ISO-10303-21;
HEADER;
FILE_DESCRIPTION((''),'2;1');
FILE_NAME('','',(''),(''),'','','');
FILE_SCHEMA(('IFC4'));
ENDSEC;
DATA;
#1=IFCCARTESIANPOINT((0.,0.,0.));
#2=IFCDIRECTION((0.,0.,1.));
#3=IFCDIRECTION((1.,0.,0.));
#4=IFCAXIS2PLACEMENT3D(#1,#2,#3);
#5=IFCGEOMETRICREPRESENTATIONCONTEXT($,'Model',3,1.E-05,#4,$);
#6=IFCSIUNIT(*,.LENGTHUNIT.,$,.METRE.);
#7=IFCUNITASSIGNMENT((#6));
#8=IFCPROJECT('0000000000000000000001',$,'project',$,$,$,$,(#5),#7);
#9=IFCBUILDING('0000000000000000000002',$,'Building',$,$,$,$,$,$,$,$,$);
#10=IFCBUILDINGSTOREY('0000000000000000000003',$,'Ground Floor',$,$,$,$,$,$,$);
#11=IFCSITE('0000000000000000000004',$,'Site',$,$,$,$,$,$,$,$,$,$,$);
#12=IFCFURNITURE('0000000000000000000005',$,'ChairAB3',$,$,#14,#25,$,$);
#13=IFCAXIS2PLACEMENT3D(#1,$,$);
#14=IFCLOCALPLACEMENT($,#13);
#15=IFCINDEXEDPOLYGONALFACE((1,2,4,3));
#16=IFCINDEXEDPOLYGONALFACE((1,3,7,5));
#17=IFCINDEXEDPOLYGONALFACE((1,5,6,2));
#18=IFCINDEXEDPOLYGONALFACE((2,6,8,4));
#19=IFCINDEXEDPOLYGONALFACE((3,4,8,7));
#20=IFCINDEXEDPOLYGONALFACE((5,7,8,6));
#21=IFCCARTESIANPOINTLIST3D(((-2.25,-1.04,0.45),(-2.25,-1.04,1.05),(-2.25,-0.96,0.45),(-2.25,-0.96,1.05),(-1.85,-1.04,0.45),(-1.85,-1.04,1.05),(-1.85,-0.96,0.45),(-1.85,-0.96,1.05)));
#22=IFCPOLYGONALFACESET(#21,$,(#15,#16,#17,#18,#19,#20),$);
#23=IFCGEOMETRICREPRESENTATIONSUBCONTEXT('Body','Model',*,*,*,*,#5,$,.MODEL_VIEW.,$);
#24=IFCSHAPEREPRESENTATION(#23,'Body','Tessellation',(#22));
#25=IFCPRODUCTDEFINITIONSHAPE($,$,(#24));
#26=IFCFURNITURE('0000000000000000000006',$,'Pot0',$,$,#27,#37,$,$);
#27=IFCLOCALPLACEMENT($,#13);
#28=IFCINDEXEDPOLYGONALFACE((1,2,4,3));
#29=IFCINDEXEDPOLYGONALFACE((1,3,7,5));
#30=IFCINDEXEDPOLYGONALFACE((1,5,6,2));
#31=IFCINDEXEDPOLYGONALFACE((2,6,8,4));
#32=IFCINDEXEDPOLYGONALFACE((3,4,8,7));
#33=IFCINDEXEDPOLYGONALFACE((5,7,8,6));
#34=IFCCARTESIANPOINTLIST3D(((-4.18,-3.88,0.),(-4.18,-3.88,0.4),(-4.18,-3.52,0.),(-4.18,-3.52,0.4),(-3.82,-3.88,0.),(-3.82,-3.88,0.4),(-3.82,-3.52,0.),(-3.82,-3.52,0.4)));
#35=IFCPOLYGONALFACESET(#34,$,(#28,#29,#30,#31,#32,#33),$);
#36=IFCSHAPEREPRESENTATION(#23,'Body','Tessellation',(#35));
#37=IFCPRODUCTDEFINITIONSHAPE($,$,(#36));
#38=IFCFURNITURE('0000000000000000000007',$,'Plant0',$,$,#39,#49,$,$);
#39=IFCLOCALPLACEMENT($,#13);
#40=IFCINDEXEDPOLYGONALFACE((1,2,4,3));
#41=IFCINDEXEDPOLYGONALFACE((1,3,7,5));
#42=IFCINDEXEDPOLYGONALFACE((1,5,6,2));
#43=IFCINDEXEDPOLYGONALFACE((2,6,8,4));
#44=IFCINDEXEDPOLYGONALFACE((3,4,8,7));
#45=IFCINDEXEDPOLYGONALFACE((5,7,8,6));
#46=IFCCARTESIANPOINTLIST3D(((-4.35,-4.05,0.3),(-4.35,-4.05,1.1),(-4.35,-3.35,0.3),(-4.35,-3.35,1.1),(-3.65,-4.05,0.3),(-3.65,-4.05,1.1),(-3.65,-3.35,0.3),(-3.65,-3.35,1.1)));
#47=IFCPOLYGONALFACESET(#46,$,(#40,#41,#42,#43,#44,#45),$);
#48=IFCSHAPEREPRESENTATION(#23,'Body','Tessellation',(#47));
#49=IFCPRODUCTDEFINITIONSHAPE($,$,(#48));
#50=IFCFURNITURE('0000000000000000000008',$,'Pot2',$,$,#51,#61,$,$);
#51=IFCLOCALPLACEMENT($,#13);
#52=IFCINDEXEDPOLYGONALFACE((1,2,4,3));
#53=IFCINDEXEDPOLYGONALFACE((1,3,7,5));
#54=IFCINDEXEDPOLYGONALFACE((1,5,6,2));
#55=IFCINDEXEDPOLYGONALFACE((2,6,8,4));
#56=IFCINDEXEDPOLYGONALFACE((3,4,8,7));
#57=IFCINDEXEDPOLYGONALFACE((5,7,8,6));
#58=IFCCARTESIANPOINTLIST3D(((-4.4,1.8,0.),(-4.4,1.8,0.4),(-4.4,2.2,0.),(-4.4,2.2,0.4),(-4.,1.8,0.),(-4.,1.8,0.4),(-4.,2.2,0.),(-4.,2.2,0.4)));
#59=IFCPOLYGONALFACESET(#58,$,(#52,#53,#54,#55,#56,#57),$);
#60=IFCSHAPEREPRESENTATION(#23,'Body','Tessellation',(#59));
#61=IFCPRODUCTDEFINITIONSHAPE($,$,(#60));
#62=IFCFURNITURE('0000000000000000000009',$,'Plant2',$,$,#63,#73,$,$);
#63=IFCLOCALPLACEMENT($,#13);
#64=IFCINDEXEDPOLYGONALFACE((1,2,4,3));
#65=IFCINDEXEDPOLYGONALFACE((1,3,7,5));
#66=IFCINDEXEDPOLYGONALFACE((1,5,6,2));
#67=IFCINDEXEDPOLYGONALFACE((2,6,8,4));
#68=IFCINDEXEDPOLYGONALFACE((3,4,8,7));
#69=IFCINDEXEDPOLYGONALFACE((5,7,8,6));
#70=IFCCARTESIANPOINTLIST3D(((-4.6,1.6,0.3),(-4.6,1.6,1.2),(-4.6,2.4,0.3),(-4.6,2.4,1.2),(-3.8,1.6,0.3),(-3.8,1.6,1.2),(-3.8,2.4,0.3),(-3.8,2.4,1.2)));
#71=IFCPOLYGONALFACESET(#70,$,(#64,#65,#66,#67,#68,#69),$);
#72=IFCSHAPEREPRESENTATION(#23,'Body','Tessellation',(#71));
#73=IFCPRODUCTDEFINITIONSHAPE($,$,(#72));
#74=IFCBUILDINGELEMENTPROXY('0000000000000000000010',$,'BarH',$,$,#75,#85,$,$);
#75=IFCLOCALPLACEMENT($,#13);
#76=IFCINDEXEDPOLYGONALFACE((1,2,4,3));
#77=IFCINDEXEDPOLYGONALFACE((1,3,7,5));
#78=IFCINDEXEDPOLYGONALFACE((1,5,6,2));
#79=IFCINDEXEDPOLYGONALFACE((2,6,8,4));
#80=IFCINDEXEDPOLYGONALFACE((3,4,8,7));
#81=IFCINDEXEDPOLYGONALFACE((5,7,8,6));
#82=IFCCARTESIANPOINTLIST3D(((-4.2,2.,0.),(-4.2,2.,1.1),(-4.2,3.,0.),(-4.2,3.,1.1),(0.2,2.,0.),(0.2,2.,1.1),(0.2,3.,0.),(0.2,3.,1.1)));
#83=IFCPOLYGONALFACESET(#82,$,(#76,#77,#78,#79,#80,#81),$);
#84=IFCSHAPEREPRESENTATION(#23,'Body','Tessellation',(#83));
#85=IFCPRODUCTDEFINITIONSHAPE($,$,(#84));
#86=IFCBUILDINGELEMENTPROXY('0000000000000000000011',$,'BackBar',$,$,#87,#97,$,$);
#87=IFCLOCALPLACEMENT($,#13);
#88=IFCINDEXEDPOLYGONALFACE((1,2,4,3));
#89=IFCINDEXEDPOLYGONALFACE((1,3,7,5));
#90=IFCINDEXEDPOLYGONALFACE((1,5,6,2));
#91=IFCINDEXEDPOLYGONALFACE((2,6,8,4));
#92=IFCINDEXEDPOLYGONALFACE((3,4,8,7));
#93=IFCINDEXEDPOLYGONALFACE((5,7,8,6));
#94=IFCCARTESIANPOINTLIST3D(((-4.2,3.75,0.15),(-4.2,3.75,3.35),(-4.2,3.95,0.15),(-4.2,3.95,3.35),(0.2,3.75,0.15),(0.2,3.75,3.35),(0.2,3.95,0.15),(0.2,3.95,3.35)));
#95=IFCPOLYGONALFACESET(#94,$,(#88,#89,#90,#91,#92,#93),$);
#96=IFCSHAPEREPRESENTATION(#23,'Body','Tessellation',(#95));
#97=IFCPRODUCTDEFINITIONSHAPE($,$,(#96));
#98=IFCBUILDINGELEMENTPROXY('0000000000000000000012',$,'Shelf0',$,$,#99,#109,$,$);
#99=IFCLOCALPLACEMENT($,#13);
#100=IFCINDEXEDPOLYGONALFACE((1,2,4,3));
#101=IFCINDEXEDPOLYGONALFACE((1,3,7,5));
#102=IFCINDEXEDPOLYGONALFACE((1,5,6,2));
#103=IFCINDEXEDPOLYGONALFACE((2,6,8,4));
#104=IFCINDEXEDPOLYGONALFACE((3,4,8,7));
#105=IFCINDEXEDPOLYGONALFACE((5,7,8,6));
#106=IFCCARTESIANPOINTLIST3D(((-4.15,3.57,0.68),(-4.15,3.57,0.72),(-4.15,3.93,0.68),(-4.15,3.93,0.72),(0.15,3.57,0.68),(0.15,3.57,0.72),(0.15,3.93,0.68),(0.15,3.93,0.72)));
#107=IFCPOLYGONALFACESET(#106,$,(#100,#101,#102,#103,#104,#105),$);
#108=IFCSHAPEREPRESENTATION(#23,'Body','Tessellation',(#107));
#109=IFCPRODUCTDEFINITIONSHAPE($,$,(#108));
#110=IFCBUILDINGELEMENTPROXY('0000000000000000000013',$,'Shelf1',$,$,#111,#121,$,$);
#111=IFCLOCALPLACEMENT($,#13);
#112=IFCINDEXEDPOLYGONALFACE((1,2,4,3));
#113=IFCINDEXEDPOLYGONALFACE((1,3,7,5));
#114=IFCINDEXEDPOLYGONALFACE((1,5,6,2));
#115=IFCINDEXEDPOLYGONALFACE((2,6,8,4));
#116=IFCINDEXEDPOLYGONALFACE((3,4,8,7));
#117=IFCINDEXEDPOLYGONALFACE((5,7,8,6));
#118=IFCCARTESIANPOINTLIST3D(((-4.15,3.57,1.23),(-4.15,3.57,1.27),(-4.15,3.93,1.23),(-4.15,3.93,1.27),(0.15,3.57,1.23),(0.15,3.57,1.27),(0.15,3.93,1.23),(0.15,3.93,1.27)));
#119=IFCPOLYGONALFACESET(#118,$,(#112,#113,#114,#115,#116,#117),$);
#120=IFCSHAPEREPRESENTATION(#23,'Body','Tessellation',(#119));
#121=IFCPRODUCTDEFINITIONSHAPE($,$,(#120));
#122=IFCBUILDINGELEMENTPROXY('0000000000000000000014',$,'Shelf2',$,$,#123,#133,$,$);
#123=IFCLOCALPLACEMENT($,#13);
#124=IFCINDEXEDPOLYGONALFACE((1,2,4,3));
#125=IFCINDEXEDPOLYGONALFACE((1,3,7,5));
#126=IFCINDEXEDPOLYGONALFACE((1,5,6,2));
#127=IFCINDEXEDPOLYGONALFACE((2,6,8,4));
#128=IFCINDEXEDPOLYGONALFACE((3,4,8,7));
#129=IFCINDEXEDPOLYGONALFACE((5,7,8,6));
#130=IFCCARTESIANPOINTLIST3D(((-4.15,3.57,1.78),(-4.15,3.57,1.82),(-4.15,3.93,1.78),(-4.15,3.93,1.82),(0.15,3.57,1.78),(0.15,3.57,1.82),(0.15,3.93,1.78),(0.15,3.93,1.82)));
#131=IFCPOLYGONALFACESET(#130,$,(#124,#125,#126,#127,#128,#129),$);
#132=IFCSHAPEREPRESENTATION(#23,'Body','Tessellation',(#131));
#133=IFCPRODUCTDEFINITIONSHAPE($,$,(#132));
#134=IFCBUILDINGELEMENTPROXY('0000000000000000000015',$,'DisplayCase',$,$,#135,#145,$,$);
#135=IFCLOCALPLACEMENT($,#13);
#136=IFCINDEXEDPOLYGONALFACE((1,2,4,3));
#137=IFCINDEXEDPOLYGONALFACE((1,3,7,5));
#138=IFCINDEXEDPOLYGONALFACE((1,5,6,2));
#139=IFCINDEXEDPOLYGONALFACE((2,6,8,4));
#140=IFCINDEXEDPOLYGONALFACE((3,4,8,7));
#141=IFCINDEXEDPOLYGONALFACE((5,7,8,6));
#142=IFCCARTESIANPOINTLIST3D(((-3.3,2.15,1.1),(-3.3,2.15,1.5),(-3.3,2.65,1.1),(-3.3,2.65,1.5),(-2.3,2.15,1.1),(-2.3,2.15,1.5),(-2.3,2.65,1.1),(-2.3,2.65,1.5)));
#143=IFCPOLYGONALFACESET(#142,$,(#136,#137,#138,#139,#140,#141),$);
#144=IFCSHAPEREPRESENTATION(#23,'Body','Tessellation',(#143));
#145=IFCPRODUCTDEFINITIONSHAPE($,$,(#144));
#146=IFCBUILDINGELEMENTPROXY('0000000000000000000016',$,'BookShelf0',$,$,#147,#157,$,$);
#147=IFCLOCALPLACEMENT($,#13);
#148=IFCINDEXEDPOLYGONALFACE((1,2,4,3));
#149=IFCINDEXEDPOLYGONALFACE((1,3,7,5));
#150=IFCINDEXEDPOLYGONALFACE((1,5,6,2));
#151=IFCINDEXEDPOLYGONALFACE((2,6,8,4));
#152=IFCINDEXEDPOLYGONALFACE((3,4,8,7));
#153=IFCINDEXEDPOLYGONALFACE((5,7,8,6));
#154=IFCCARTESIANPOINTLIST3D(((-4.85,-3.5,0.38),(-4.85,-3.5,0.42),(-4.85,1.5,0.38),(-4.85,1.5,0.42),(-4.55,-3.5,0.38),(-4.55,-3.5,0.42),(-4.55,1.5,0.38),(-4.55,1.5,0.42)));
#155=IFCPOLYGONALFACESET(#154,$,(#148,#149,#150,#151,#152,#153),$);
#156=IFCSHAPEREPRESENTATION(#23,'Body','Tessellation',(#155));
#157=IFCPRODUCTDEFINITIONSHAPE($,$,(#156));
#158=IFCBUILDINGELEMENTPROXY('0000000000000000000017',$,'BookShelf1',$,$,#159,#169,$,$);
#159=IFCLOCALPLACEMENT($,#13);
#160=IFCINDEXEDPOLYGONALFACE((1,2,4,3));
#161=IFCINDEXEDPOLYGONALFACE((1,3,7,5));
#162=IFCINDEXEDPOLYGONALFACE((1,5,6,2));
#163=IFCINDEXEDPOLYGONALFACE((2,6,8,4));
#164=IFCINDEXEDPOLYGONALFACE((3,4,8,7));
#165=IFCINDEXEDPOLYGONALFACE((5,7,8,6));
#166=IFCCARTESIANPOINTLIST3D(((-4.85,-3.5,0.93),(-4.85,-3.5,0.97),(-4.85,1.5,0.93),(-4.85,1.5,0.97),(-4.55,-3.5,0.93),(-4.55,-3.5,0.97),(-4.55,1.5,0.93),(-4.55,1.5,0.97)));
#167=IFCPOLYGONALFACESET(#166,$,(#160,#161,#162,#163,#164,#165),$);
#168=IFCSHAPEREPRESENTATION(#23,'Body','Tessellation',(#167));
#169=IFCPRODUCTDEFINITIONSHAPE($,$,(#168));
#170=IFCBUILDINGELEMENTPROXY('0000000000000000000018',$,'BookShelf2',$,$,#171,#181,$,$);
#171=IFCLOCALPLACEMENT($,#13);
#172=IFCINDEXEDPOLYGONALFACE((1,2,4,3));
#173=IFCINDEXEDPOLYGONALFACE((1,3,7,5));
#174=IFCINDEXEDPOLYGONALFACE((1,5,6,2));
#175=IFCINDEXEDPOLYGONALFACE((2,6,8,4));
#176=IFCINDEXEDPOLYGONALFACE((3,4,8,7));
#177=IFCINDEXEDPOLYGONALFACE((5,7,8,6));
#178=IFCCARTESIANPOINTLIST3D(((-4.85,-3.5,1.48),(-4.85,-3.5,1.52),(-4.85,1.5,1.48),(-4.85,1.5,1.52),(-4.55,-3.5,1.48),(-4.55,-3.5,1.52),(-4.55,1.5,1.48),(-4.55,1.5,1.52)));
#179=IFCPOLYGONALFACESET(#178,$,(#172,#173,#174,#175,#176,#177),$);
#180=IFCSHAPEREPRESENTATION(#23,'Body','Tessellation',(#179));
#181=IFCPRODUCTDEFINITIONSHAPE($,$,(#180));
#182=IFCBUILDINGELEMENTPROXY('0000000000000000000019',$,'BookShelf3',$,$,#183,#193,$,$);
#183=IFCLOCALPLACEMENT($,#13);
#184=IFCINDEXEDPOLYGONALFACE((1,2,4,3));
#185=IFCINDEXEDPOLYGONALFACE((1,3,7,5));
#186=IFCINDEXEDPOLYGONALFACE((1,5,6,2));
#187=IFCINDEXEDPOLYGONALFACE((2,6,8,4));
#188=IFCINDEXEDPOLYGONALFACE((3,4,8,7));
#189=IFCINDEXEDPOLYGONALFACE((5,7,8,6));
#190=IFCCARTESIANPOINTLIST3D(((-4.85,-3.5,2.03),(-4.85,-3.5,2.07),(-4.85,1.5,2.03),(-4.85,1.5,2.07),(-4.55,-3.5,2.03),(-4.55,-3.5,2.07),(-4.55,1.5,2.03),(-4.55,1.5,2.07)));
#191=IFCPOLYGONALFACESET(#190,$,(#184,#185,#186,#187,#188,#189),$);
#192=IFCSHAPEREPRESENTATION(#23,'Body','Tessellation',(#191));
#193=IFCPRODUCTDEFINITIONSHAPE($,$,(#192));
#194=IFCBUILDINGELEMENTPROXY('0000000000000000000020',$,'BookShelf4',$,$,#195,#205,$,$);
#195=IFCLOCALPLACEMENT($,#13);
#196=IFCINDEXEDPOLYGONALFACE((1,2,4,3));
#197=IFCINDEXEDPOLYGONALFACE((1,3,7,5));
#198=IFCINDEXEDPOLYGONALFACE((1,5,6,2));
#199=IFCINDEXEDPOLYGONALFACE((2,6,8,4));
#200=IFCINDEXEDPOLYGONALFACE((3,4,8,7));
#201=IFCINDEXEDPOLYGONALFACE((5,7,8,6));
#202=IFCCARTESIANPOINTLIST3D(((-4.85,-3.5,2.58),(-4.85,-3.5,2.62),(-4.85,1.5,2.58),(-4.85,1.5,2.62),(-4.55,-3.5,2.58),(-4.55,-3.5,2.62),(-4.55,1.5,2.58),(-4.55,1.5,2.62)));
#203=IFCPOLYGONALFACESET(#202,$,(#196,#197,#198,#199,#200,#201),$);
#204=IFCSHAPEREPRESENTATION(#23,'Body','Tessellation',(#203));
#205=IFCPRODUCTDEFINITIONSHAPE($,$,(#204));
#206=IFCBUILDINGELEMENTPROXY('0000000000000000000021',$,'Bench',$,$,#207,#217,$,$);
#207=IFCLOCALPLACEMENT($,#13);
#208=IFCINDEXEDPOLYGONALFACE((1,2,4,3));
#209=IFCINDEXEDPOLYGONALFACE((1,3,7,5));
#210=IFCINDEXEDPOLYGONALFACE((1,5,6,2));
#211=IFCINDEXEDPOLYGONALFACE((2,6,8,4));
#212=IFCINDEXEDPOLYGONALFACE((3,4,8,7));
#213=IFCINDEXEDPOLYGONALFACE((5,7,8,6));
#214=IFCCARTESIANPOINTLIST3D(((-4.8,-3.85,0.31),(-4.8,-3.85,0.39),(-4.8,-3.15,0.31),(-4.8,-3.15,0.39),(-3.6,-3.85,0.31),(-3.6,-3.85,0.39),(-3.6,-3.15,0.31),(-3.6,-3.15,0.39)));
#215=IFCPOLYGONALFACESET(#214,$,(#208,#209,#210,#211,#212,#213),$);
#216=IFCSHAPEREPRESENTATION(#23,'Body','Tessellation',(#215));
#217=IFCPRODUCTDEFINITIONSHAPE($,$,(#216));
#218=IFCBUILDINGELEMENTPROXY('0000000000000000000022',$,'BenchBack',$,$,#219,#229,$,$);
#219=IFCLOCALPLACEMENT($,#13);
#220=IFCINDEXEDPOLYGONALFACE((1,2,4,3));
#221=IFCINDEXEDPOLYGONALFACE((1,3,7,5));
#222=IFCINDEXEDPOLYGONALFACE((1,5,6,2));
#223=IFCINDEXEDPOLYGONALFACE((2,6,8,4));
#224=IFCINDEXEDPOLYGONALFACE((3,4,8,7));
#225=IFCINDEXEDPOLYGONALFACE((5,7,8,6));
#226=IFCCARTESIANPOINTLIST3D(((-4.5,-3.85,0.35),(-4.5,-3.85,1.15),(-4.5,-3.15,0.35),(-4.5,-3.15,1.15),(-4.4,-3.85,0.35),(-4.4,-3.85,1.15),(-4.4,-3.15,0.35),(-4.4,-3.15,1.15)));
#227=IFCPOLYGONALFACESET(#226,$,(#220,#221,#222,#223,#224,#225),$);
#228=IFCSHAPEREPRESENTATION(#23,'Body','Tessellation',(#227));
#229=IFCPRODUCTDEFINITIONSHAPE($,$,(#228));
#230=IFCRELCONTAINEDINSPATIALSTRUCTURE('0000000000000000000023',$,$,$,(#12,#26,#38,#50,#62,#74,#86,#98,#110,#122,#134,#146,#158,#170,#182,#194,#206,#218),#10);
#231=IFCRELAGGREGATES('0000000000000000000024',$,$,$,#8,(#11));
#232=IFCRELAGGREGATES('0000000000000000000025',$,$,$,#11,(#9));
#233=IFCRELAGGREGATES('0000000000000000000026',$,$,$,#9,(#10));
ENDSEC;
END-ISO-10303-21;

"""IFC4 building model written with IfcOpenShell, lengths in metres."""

from ifc_helpers import new_model, si_unit, frame, origin_with_axes, origin_2d, place, context, subcontext, project, spatial, rectangle, extrude, element, save


model = new_model("IFC4")

# Units and contexts
model_context = context("Model", 3, precision=1e-05, world=origin_with_axes())
body_context = subcontext(model_context, "Body", "Model", "MODEL_VIEW")
ifc_project = project(units=[si_unit("LENGTHUNIT", "METRE")], contexts=[model_context])

# Site, building, storey
site = spatial("IfcSite", under=ifc_project, Name="Site")
building = spatial("IfcBuilding", under=site, Name="Building")
storey = spatial("IfcBuildingStorey", under=building, Name="Ground Floor")

# Furniture
furniture_1_placement = place(None, frame((-2.05, -1.0, 0.75), z_axis=(0.0, 0.0, 1.0), x_axis=(1.0, 0.0, 0.0)))
element("IfcFurniture", 1, at=furniture_1_placement, inside=storey, Name="ChairAB3", context=body_context, shape_type="SweptSolid", body=[
    extrude(rectangle(XDim=0.4, YDim=0.08, at=origin_2d()), frame((0.0, 0.0, -0.3)), (0.0, 0.0, 1.0), 0.6),
])
furniture_2_placement = place(None, frame((-4.0, -3.7, 0.2), z_axis=(0.0, 0.0, 1.0), x_axis=(1.0, 0.0, 0.0)))
element("IfcFurniture", 2, at=furniture_2_placement, inside=storey, Name="Pot0", context=body_context, shape_type="SweptSolid", body=[
    extrude(rectangle(XDim=0.36, YDim=0.36, at=origin_2d()), frame((0.0, 0.0, -0.2)), (0.0, 0.0, 1.0), 0.4),
])
furniture_3_placement = place(None, frame((-4.0, -3.7, 0.7), z_axis=(0.0, 0.0, 1.0), x_axis=(1.0, 0.0, 0.0)))
element("IfcFurniture", 3, at=furniture_3_placement, inside=storey, Name="Plant0", context=body_context, shape_type="SweptSolid", body=[
    extrude(rectangle(XDim=0.7, YDim=0.7, at=origin_2d()), frame((0.0, 0.0, -0.4)), (0.0, 0.0, 1.0), 0.8),
])
furniture_4_placement = place(None, frame((-4.2, 2.0, 0.2), z_axis=(0.0, 0.0, 1.0), x_axis=(1.0, 0.0, 0.0)))
element("IfcFurniture", 4, at=furniture_4_placement, inside=storey, Name="Pot2", context=body_context, shape_type="SweptSolid", body=[
    extrude(rectangle(XDim=0.4, YDim=0.4, at=origin_2d()), frame((0.0, 0.0, -0.2)), (0.0, 0.0, 1.0), 0.4),
])
furniture_5_placement = place(None, frame((-4.2, 2.0, 0.75), z_axis=(0.0, 0.0, 1.0), x_axis=(1.0, 0.0, 0.0)))
element("IfcFurniture", 5, at=furniture_5_placement, inside=storey, Name="Plant2", context=body_context, shape_type="SweptSolid", body=[
    extrude(rectangle(XDim=0.8, YDim=0.8, at=origin_2d()), frame((0.0, 0.0, -0.45)), (0.0, 0.0, 1.0), 0.9),
])

# Building element proxies
proxy_1_placement = place(None, frame((-2.0, 2.5, 0.55), z_axis=(0.0, 0.0, 1.0), x_axis=(1.0, 0.0, 0.0)))
element("IfcBuildingElementProxy", 6, at=proxy_1_placement, inside=storey, Name="BarH", context=body_context, shape_type="SweptSolid", body=[
    extrude(rectangle(XDim=4.4, YDim=1.0, at=origin_2d()), frame((0.0, 0.0, -0.55)), (0.0, 0.0, 1.0), 1.1),
])
proxy_2_placement = place(None, frame((-2.0, 3.85, 1.75), z_axis=(0.0, 0.0, 1.0), x_axis=(1.0, 0.0, 0.0)))
element("IfcBuildingElementProxy", 7, at=proxy_2_placement, inside=storey, Name="BackBar", context=body_context, shape_type="SweptSolid", body=[
    extrude(rectangle(XDim=4.4, YDim=0.2, at=origin_2d()), frame((0.0, 0.0, -1.6)), (0.0, 0.0, 1.0), 3.2),
])
for number, where, z_axis, x_axis, name in (
    (8, (-2.0, 3.75, 0.7), (0.0, 0.0, 1.0), (1.0, 0.0, 0.0), "Shelf0"),
    (9, (-2.0, 3.75, 1.25), (0.0, 0.0, 1.0), (1.0, 0.0, 0.0), "Shelf1"),
    (10, (-2.0, 3.75, 1.8), (0.0, 0.0, 1.0), (1.0, 0.0, 0.0), "Shelf2"),
):
    element("IfcBuildingElementProxy", number, at=place(None, frame(where, z_axis=z_axis, x_axis=x_axis)), inside=storey, Name=name, context=body_context, shape_type="SweptSolid", body=[
        extrude(rectangle(XDim=4.3, YDim=0.36, at=origin_2d()), frame((0.0, 0.0, -0.02)), (0.0, 0.0, 1.0), 0.04),
    ])
proxy_3_placement = place(None, frame((-2.8, 2.4, 1.3), z_axis=(0.0, 0.0, 1.0), x_axis=(1.0, 0.0, 0.0)))
element("IfcBuildingElementProxy", 11, at=proxy_3_placement, inside=storey, Name="DisplayCase", context=body_context, shape_type="SweptSolid", body=[
    extrude(rectangle(XDim=1.0, YDim=0.5, at=origin_2d()), frame((0.0, 0.0, -0.2)), (0.0, 0.0, 1.0), 0.4),
])
for number, where, z_axis, x_axis, name in (
    (12, (-4.7, -1.0, 0.4), (0.0, 0.0, 1.0), (1.0, 0.0, 0.0), "BookShelf0"),
    (13, (-4.7, -1.0, 0.95), (0.0, 0.0, 1.0), (1.0, 0.0, 0.0), "BookShelf1"),
    (14, (-4.7, -1.0, 1.5), (0.0, 0.0, 1.0), (1.0, 0.0, 0.0), "BookShelf2"),
    (15, (-4.7, -1.0, 2.05), (0.0, 0.0, 1.0), (1.0, 0.0, 0.0), "BookShelf3"),
    (16, (-4.7, -1.0, 2.6), (0.0, 0.0, 1.0), (1.0, 0.0, 0.0), "BookShelf4"),
):
    element("IfcBuildingElementProxy", number, at=place(None, frame(where, z_axis=z_axis, x_axis=x_axis)), inside=storey, Name=name, context=body_context, shape_type="SweptSolid", body=[
        extrude(rectangle(XDim=0.3, YDim=5.0, at=origin_2d()), frame((0.0, 0.0, -0.02)), (0.0, 0.0, 1.0), 0.04),
    ])
proxy_4_placement = place(None, frame((-4.2, -3.5, 0.35), z_axis=(0.0, 0.0, 1.0), x_axis=(1.0, 0.0, 0.0)))
element("IfcBuildingElementProxy", 17, at=proxy_4_placement, inside=storey, Name="Bench", context=body_context, shape_type="SweptSolid", body=[
    extrude(rectangle(XDim=1.2, YDim=0.7, at=origin_2d()), frame((0.0, 0.0, -0.04)), (0.0, 0.0, 1.0), 0.08),
])
proxy_5_placement = place(None, frame((-4.45, -3.5, 0.75), z_axis=(0.0, 0.0, 1.0), x_axis=(1.0, 0.0, 0.0)))
element("IfcBuildingElementProxy", 18, at=proxy_5_placement, inside=storey, Name="BenchBack", context=body_context, shape_type="SweptSolid", body=[
    extrude(rectangle(XDim=0.1, YDim=0.7, at=origin_2d()), frame((0.0, 0.0, -0.4)), (0.0, 0.0, 1.0), 0.8),
])

save(model, "model.ifc")
